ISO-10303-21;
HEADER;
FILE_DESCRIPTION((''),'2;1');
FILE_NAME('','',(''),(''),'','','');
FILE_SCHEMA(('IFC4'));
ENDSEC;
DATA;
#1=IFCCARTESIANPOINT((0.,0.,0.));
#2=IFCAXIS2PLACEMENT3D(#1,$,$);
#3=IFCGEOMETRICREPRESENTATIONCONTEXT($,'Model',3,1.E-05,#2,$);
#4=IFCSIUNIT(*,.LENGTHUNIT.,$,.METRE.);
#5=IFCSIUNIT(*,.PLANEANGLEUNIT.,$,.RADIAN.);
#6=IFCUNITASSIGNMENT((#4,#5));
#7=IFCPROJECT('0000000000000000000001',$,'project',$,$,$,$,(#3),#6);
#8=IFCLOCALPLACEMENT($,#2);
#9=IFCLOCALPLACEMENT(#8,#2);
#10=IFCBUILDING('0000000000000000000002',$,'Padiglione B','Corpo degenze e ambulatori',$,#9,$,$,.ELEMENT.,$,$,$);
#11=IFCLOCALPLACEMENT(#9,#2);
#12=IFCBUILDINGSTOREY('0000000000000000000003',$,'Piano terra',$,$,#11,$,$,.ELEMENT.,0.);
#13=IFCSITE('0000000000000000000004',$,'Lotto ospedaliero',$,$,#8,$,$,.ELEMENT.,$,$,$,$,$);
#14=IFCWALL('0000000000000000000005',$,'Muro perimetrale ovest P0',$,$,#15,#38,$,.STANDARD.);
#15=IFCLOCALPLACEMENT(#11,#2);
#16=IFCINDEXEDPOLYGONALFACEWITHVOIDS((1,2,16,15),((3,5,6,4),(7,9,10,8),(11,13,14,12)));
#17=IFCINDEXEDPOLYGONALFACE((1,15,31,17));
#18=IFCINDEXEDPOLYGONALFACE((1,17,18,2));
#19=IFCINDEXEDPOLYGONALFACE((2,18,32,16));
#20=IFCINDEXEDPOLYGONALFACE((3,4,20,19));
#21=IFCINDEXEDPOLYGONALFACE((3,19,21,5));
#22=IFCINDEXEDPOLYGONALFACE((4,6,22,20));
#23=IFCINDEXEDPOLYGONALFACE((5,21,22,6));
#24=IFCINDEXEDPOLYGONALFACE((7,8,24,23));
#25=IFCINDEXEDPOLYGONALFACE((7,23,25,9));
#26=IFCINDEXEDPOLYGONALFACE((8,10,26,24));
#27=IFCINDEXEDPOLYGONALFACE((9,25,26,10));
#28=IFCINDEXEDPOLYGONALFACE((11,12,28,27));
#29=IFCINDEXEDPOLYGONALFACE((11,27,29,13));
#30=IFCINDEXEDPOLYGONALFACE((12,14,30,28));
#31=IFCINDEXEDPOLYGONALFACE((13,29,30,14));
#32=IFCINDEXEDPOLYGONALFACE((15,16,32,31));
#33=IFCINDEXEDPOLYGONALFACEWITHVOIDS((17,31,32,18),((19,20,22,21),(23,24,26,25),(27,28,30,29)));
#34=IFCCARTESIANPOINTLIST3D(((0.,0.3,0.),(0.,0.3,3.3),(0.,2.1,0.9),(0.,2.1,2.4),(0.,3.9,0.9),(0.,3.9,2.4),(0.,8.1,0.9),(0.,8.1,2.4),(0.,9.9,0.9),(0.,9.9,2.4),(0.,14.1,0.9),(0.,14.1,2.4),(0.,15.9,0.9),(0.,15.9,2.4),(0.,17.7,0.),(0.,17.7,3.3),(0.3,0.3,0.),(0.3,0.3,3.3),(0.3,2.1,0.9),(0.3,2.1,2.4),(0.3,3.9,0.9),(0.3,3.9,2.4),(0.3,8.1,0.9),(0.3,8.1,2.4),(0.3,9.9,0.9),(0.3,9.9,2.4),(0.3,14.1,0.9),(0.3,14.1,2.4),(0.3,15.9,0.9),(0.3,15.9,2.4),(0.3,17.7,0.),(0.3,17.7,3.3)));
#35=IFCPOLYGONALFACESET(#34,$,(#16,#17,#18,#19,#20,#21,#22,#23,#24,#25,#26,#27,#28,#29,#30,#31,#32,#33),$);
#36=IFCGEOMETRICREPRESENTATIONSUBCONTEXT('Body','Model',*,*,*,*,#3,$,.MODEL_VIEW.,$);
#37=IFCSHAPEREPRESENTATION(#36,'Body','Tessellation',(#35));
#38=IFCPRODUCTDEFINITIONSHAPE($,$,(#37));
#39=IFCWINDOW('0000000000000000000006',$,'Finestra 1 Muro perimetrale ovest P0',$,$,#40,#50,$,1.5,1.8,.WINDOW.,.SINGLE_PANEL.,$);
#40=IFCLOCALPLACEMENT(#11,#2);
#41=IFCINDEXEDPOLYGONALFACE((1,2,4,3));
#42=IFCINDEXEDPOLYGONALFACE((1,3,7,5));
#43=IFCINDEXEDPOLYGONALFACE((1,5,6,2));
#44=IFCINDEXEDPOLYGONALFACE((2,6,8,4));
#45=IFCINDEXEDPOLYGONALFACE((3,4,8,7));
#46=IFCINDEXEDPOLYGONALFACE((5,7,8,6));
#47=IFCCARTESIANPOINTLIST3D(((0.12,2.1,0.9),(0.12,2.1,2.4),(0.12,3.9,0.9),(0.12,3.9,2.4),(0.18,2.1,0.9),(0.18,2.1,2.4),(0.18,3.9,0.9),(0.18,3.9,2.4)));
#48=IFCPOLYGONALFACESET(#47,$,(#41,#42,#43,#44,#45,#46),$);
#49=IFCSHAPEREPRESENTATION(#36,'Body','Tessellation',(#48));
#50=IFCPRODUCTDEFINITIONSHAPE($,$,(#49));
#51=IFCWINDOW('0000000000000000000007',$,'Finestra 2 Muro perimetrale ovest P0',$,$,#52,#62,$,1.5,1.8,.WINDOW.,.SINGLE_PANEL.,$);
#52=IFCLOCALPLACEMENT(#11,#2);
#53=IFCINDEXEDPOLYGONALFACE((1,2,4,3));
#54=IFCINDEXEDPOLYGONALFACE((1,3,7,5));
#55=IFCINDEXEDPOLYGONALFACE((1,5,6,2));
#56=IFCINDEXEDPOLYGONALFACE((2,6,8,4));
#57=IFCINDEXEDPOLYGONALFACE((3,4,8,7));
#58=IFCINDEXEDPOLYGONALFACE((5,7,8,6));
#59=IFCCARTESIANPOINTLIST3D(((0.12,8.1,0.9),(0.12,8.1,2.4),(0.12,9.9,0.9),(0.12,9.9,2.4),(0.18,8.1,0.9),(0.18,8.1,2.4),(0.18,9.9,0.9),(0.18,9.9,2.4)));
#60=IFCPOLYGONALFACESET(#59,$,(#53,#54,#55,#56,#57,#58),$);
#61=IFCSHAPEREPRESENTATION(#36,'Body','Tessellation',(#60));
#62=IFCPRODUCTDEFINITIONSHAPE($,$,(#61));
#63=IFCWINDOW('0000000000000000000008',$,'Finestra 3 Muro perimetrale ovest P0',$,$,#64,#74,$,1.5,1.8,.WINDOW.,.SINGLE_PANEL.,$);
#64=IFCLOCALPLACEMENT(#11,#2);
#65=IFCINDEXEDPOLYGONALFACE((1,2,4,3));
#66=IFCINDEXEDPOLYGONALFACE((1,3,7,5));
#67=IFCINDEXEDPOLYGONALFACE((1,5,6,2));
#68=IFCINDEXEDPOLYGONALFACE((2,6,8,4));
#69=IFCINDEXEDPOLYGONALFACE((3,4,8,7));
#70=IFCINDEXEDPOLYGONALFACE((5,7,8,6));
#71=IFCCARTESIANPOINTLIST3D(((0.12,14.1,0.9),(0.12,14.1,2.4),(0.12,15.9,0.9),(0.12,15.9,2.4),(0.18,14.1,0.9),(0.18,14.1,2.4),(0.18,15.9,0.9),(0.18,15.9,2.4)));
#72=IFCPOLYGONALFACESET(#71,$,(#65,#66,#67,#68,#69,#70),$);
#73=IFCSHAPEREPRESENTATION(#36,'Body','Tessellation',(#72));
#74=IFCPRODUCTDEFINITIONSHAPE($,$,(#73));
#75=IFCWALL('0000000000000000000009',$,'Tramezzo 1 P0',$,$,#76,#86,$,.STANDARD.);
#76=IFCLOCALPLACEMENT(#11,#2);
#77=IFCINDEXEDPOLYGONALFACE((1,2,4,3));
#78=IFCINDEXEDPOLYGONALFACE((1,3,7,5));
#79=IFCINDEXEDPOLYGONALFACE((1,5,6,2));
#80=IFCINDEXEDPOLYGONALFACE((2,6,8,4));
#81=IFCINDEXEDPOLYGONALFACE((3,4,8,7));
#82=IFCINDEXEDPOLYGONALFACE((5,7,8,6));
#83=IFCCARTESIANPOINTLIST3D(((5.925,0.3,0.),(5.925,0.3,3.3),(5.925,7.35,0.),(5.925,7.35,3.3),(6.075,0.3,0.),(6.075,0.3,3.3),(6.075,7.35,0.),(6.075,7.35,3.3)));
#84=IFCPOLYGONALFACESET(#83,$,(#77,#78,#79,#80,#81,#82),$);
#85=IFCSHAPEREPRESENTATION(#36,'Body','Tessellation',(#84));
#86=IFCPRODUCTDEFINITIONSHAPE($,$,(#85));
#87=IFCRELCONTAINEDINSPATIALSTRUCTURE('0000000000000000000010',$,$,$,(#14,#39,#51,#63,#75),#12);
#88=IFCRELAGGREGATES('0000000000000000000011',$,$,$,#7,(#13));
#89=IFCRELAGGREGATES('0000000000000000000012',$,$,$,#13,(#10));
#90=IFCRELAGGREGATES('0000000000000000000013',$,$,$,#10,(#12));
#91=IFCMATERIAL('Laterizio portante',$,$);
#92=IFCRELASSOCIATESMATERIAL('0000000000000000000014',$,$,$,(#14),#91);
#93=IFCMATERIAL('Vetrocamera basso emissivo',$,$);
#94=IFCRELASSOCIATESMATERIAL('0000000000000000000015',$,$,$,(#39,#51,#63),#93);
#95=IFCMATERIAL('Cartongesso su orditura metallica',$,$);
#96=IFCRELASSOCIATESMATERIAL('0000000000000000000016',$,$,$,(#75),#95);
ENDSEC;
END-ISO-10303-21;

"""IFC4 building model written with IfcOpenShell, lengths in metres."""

from ifc_helpers import new_model, si_unit, frame, frame_2d, origin, place, context, subcontext, project, spatial, rectangle, extrude, material, element, fill, save


model = new_model("IFC4")

# Units and contexts
model_context = context("Model", 3, precision=1e-05, world=origin())
body_context = subcontext(model_context, "Body", "Model", "MODEL_VIEW")
ifc_project = project(units=[si_unit("LENGTHUNIT", "METRE"), si_unit("PLANEANGLEUNIT", "RADIAN")], contexts=[model_context])

# Site, building, storey
site_placement = place(None, origin())
site = spatial("IfcSite", under=ifc_project, at=site_placement, Name="Lotto ospedaliero", CompositionType="ELEMENT")
building_placement = place(site_placement, origin())
building = spatial("IfcBuilding", under=site, at=building_placement, Name="Padiglione B", Description="Corpo degenze e ambulatori", CompositionType="ELEMENT")
storey_placement = place(building_placement, origin())
storey = spatial("IfcBuildingStorey", under=building, at=storey_placement, Name="Piano terra", CompositionType="ELEMENT", Elevation=0.0)

# Shared definitions
ifc_material_1 = material(Name="Laterizio portante")
ifc_material_2 = material(Name="Vetrocamera basso emissivo")

# Wall, openings, windows
wall_1_placement = place(storey_placement, frame((0.0, 0.3, 0.0)))
wall_1 = element("IfcWall", 1, at=wall_1_placement, inside=storey, material=ifc_material_1, Name="Muro perimetrale ovest P0", PredefinedType="STANDARD", context=body_context, shape_type="SweptSolid", body=[
    extrude(rectangle(XDim=0.3, YDim=17.4, at=frame_2d((0.15, 8.7))), origin(), (0.0, 0.0, 1.0), 3.3),
])
opening_1_placement = place(wall_1_placement, frame((-0.1, 1.8, 0.9)))
opening_1 = element("IfcOpeningElement", 2, at=opening_1_placement, cuts=wall_1, PredefinedType="OPENING", context=body_context, shape_type="SweptSolid", body=[
    extrude(rectangle(XDim=0.5, YDim=1.8, at=frame_2d((0.25, 0.9))), origin(), (0.0, 0.0, 1.0), 1.5),
])
opening_2_placement = place(wall_1_placement, frame((-0.1, 7.8, 0.9)))
opening_2 = element("IfcOpeningElement", 3, at=opening_2_placement, cuts=wall_1, PredefinedType="OPENING", context=body_context, shape_type="SweptSolid", body=[
    extrude(rectangle(XDim=0.5, YDim=1.8, at=frame_2d((0.25, 0.9))), origin(), (0.0, 0.0, 1.0), 1.5),
])
opening_3_placement = place(wall_1_placement, frame((-0.1, 13.8, 0.9)))
opening_3 = element("IfcOpeningElement", 4, at=opening_3_placement, cuts=wall_1, PredefinedType="OPENING", context=body_context, shape_type="SweptSolid", body=[
    extrude(rectangle(XDim=0.5, YDim=1.8, at=frame_2d((0.25, 0.9))), origin(), (0.0, 0.0, 1.0), 1.5),
])
window_1_placement = place(wall_1_placement, frame((0.12, 1.8, 0.9)))
window_1 = element("IfcWindow", 5, at=window_1_placement, inside=storey, material=ifc_material_2, Name="Finestra 1 Muro perimetrale ovest P0", OverallHeight=1.5, OverallWidth=1.8, PartitioningType="SINGLE_PANEL", PredefinedType="WINDOW", context=body_context, shape_type="SweptSolid", body=[
    extrude(rectangle(XDim=0.06, YDim=1.8, at=frame_2d((0.03, 0.9))), origin(), (0.0, 0.0, 1.0), 1.5),
])
fill(opening_1, window_1)
window_2_placement = place(wall_1_placement, frame((0.12, 7.8, 0.9)))
window_2 = element("IfcWindow", 6, at=window_2_placement, inside=storey, material=ifc_material_2, Name="Finestra 2 Muro perimetrale ovest P0", OverallHeight=1.5, OverallWidth=1.8, PartitioningType="SINGLE_PANEL", PredefinedType="WINDOW", context=body_context, shape_type="SweptSolid", body=[
    extrude(rectangle(XDim=0.06, YDim=1.8, at=frame_2d((0.03, 0.9))), origin(), (0.0, 0.0, 1.0), 1.5),
])
fill(opening_2, window_2)
window_3_placement = place(wall_1_placement, frame((0.12, 13.8, 0.9)))
window_3 = element("IfcWindow", 7, at=window_3_placement, inside=storey, material=ifc_material_2, Name="Finestra 3 Muro perimetrale ovest P0", OverallHeight=1.5, OverallWidth=1.8, PartitioningType="SINGLE_PANEL", PredefinedType="WINDOW", context=body_context, shape_type="SweptSolid", body=[
    extrude(rectangle(XDim=0.06, YDim=1.8, at=frame_2d((0.03, 0.9))), origin(), (0.0, 0.0, 1.0), 1.5),
])
fill(opening_3, window_3)

# Wall
ifc_material_3 = material(Name="Cartongesso su orditura metallica")
wall_2_placement = place(storey_placement, frame((5.925, 0.3, 0.0)))
element("IfcWall", 8, at=wall_2_placement, inside=storey, material=ifc_material_3, Name="Tramezzo 1 P0", PredefinedType="STANDARD", context=body_context, shape_type="SweptSolid", body=[
    extrude(rectangle(XDim=0.15, YDim=7.05, at=frame_2d((0.075, 3.525))), origin(), (0.0, 0.0, 1.0), 3.3),
])

save(model, "model.ifc")
